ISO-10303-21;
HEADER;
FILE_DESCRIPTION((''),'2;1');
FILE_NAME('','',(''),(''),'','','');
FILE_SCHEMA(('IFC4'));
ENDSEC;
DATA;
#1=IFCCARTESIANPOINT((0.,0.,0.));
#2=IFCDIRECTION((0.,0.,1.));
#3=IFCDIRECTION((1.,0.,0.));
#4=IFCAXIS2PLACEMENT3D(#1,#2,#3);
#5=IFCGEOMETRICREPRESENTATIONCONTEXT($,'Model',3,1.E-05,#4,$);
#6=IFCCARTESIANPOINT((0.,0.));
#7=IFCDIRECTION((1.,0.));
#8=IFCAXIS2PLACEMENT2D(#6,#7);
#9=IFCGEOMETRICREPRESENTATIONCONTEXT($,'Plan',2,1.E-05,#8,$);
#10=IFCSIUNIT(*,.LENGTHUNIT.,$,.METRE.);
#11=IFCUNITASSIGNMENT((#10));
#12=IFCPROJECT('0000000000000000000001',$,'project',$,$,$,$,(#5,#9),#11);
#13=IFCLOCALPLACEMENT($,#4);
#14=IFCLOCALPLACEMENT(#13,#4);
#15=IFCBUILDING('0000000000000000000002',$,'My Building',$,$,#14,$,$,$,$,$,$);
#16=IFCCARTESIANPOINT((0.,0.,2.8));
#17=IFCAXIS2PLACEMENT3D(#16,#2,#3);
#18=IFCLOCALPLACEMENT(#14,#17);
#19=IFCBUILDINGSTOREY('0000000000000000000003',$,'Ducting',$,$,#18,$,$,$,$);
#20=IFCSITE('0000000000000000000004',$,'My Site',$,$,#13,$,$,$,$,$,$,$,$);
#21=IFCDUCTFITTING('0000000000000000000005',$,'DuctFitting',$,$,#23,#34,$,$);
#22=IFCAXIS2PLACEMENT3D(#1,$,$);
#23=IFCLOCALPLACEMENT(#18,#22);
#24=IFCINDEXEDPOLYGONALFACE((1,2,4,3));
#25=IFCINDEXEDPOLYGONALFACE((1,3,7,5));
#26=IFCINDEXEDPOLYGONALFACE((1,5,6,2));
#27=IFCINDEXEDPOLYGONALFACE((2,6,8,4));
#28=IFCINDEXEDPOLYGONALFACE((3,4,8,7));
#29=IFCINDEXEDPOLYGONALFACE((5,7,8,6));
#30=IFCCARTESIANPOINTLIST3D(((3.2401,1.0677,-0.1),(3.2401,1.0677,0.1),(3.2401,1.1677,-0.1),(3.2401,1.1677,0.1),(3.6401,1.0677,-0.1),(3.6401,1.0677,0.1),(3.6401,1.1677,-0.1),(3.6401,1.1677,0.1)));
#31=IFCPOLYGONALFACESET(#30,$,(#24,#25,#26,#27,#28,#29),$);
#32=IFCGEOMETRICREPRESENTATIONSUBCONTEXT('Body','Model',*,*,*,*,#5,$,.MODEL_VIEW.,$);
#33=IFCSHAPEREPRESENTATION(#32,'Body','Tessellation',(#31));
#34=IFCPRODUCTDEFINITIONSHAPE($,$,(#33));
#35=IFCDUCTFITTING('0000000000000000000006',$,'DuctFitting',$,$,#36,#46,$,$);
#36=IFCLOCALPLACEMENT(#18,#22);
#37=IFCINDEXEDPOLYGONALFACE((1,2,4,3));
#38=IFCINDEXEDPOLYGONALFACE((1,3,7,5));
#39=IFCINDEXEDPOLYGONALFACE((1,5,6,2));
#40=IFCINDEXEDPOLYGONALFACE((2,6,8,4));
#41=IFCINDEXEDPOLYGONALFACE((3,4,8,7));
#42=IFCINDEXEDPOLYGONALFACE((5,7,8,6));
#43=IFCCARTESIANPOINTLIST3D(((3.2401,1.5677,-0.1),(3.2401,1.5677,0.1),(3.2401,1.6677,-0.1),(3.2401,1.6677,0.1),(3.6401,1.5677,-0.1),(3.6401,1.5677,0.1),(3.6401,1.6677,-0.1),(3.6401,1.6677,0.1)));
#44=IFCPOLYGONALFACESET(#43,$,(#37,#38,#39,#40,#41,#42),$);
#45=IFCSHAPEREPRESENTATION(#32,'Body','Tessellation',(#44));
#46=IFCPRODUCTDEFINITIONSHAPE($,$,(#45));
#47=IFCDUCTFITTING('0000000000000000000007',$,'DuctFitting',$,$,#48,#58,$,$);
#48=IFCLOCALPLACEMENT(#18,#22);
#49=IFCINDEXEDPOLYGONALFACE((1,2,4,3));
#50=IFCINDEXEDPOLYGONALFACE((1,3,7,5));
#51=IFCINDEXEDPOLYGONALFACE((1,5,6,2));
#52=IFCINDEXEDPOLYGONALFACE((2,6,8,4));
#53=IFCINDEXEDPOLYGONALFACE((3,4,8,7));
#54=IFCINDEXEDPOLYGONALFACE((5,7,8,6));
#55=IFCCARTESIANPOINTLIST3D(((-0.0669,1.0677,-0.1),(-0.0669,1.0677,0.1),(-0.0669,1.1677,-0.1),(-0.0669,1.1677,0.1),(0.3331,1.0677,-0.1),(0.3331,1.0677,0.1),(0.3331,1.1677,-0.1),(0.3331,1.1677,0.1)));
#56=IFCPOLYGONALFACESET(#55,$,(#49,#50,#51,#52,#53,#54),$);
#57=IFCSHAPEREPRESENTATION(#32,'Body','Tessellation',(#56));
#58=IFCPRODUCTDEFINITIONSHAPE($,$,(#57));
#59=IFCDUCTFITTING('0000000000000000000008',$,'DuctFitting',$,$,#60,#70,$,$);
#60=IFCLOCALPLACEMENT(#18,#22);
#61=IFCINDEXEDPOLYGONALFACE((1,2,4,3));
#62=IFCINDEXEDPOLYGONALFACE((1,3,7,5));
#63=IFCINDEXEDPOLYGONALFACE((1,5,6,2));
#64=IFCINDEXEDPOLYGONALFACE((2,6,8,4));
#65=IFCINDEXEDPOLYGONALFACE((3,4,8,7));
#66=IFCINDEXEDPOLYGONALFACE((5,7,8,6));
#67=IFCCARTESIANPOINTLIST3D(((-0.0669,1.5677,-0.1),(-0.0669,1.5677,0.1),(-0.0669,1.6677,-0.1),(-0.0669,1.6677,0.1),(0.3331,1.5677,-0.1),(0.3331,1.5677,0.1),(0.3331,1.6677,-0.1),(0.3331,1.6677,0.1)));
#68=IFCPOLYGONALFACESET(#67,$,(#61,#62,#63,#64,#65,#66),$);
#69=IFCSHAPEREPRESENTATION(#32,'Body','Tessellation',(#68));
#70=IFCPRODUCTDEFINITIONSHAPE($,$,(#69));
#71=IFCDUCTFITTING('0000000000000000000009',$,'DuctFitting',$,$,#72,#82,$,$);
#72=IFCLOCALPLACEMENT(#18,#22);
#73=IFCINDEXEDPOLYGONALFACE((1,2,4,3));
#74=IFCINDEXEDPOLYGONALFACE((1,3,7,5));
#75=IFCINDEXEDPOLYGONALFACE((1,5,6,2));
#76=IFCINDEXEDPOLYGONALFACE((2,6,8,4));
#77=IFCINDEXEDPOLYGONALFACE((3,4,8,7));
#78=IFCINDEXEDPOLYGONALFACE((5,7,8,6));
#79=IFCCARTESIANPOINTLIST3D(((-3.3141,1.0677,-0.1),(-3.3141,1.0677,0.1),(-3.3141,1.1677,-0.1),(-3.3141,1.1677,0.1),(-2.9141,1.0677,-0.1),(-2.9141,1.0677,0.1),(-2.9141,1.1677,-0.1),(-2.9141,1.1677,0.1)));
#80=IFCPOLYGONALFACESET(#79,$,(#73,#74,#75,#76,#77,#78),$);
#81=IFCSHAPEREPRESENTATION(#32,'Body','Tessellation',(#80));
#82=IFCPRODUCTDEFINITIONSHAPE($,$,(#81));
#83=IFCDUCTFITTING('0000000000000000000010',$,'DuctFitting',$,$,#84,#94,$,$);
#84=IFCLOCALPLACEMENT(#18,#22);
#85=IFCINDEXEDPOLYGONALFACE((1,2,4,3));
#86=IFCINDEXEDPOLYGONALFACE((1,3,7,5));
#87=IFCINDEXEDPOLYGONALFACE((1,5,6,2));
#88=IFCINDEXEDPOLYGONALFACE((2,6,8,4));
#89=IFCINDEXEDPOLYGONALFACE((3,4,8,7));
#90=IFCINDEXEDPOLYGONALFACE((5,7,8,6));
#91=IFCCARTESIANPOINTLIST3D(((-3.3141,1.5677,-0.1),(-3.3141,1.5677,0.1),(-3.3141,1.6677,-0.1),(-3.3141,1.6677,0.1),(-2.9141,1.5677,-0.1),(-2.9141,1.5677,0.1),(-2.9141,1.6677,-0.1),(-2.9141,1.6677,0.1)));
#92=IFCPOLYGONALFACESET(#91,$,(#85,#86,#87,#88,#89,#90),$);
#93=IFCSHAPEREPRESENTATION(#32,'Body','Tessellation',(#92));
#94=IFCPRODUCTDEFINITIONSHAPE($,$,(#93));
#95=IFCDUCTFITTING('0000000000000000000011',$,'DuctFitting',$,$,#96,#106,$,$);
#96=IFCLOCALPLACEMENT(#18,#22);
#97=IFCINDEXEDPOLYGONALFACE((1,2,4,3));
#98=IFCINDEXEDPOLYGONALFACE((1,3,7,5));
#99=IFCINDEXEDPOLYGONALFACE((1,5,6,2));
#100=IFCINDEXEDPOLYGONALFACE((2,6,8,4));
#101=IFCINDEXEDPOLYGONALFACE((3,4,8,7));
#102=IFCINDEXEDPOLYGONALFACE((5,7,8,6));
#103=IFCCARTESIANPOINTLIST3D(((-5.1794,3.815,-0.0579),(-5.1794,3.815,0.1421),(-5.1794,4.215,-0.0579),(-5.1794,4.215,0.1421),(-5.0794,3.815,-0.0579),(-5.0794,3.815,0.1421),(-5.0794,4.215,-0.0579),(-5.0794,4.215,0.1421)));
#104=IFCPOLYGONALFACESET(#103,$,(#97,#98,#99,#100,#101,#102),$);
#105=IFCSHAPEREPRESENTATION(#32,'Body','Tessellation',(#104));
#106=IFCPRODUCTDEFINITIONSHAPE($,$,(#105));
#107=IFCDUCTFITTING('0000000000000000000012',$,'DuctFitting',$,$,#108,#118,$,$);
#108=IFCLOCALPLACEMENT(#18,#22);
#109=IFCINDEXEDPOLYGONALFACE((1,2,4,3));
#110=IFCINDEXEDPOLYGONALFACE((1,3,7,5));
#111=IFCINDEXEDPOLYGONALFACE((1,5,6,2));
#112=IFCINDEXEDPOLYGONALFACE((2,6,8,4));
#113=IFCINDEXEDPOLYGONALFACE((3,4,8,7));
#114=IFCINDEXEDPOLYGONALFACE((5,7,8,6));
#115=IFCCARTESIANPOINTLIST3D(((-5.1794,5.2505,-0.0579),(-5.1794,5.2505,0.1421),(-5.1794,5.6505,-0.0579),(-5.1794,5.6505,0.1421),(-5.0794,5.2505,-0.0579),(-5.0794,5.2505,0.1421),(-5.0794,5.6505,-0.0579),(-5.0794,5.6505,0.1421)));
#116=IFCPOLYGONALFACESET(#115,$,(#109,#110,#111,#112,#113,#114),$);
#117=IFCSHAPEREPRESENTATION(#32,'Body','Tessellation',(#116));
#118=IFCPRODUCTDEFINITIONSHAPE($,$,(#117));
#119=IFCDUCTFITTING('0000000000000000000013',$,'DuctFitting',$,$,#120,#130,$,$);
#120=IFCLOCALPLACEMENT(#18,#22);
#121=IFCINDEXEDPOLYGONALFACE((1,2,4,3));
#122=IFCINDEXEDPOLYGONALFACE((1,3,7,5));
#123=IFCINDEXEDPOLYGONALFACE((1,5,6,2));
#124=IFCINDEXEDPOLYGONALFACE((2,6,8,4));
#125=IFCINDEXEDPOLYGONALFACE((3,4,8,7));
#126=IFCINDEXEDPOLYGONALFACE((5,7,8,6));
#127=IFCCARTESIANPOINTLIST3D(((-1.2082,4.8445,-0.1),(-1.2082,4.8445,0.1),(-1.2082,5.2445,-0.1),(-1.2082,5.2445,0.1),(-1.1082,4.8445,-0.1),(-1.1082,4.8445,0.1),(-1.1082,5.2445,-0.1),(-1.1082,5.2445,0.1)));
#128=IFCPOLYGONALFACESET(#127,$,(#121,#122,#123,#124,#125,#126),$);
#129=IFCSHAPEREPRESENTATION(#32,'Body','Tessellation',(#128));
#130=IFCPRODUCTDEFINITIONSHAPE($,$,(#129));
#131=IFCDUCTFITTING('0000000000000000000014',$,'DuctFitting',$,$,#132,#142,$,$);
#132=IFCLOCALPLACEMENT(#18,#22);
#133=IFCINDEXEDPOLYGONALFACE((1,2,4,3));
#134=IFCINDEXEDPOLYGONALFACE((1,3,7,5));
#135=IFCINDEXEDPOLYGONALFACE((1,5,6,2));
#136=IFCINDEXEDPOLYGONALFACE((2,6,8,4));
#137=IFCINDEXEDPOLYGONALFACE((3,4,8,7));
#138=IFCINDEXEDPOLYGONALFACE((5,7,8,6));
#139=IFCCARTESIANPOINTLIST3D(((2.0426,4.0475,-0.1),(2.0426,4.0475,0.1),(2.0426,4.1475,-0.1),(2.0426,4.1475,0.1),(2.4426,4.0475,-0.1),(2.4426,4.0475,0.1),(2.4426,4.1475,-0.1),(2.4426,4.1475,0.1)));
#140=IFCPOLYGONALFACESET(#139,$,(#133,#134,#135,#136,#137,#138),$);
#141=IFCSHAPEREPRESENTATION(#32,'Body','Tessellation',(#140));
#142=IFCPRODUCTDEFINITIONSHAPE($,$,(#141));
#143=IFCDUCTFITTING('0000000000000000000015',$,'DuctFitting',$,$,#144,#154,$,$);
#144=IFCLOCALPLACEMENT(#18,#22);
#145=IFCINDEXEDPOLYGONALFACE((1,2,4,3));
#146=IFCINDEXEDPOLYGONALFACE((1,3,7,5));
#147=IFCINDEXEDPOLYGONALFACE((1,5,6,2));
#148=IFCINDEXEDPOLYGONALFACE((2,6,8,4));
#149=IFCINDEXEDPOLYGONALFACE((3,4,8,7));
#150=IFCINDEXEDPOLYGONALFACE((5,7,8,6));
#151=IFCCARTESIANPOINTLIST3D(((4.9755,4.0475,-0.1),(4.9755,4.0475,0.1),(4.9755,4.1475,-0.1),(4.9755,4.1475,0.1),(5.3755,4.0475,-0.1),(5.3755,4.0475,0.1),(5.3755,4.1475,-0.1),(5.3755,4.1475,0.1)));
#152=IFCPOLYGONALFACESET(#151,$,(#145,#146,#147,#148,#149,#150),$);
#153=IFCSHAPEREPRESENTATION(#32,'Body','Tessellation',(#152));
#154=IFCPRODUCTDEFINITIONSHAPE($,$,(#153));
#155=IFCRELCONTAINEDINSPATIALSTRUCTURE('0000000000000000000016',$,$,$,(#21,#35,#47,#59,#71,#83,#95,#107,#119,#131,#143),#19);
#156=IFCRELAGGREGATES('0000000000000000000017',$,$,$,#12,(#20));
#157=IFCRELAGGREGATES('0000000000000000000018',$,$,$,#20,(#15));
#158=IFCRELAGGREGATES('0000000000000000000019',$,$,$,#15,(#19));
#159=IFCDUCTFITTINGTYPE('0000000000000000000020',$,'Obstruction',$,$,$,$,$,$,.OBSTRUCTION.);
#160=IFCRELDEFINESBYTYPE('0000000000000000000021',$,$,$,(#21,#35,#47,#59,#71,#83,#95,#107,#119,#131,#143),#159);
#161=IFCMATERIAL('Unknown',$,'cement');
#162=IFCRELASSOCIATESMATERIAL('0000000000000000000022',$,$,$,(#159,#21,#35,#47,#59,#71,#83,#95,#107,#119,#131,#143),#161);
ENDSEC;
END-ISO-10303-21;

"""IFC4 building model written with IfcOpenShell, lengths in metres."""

from ifc_helpers import new_model, si_unit, frame, origin_with_axes, origin_2d_with_axis, place, context, subcontext, project, spatial, rectangle, extrude, material, material_profile, profile_set, profile_usage, type_object, element, save


model = new_model("IFC4")

# Units and contexts
model_context = context("Model", 3, precision=1e-05, world=origin_with_axes())
plan_context = context("Plan", 2, precision=1e-05, world=origin_2d_with_axis())
body_context = subcontext(model_context, "Body", "Model", "MODEL_VIEW")
ifc_project = project(units=[si_unit("LENGTHUNIT", "METRE")], contexts=[model_context, plan_context])

# Site, building, storey
site_placement = place(None, origin_with_axes())
site = spatial("IfcSite", under=ifc_project, at=site_placement, Name="My Site")
building_placement = place(site_placement, origin_with_axes())
building = spatial("IfcBuilding", under=site, at=building_placement, Name="My Building")
storey_placement = place(building_placement, frame((0.0, 0.0, 2.8), z_axis=(0.0, 0.0, 1.0), x_axis=(1.0, 0.0, 0.0)))
storey = spatial("IfcBuildingStorey", under=building, at=storey_placement, Name="Ducting")

# Shared definitions
ifc_material = material(Name="Unknown", Category="cement")

# Duct fittings
ifc_material_profile_1 = material_profile(ifc_material, rectangle(XDim=0.4, YDim=0.2))
ifc_profile_set_1 = profile_set([ifc_material_profile_1])
ifc_profile_usage_1 = profile_usage(ifc_profile_set_1, cardinal=5)
duct_fitting_type_1 = type_object("IfcDuctFittingType", Name="Obstruction", PredefinedType="OBSTRUCTION", material=ifc_profile_set_1)
duct_fitting_1_placement = place(storey_placement, frame((3.4401, 1.0677, 0.0), z_axis=(0.0, 1.0, 0.0), x_axis=(-1.0, 0.0, 0.0)))
element("IfcDuctFitting", 1, at=duct_fitting_1_placement, inside=storey, type_object=duct_fitting_type_1, material=ifc_profile_usage_1, Name="DuctFitting", context=body_context, shape_type="SweptSolid", body=[
    extrude(rectangle(XDim=0.4, YDim=0.2), origin_with_axes(), (0.0, 0.0, 1.0), 0.1),
])
ifc_profile_usage_2 = profile_usage(ifc_profile_set_1, cardinal=5)
duct_fitting_2_placement = place(storey_placement, frame((3.4401, 1.6677, 0.0), z_axis=(0.0, -1.0, 0.0), x_axis=(1.0, 0.0, 0.0)))
element("IfcDuctFitting", 2, at=duct_fitting_2_placement, inside=storey, type_object=duct_fitting_type_1, material=ifc_profile_usage_2, Name="DuctFitting", context=body_context, shape_type="SweptSolid", body=[
    extrude(rectangle(XDim=0.4, YDim=0.2), origin_with_axes(), (0.0, 0.0, 1.0), 0.1),
])
ifc_profile_usage_3 = profile_usage(ifc_profile_set_1, cardinal=5)
duct_fitting_3_placement = place(storey_placement, frame((0.1331, 1.0677, 0.0), z_axis=(0.0, 1.0, 0.0), x_axis=(-1.0, 0.0, 0.0)))
element("IfcDuctFitting", 3, at=duct_fitting_3_placement, inside=storey, type_object=duct_fitting_type_1, material=ifc_profile_usage_3, Name="DuctFitting", context=body_context, shape_type="SweptSolid", body=[
    extrude(rectangle(XDim=0.4, YDim=0.2), origin_with_axes(), (0.0, 0.0, 1.0), 0.1),
])
ifc_profile_usage_4 = profile_usage(ifc_profile_set_1, cardinal=5)
duct_fitting_4_placement = place(storey_placement, frame((0.1331, 1.6677, 0.0), z_axis=(0.0, -1.0, 0.0), x_axis=(1.0, 0.0, 0.0)))
element("IfcDuctFitting", 4, at=duct_fitting_4_placement, inside=storey, type_object=duct_fitting_type_1, material=ifc_profile_usage_4, Name="DuctFitting", context=body_context, shape_type="SweptSolid", body=[
    extrude(rectangle(XDim=0.4, YDim=0.2), origin_with_axes(), (0.0, 0.0, 1.0), 0.1),
])
ifc_profile_usage_5 = profile_usage(ifc_profile_set_1, cardinal=5)
duct_fitting_5_placement = place(storey_placement, frame((-3.1141, 1.0677, 0.0), z_axis=(0.0, 1.0, 0.0), x_axis=(-1.0, 0.0, 0.0)))
element("IfcDuctFitting", 5, at=duct_fitting_5_placement, inside=storey, type_object=duct_fitting_type_1, material=ifc_profile_usage_5, Name="DuctFitting", context=body_context, shape_type="SweptSolid", body=[
    extrude(rectangle(XDim=0.4, YDim=0.2), origin_with_axes(), (0.0, 0.0, 1.0), 0.1),
])
ifc_profile_usage_6 = profile_usage(ifc_profile_set_1, cardinal=5)
duct_fitting_6_placement = place(storey_placement, frame((-3.1141, 1.6677, 0.0), z_axis=(0.0, -1.0, 0.0), x_axis=(1.0, 0.0, 0.0)))
element("IfcDuctFitting", 6, at=duct_fitting_6_placement, inside=storey, type_object=duct_fitting_type_1, material=ifc_profile_usage_6, Name="DuctFitting", context=body_context, shape_type="SweptSolid", body=[
    extrude(rectangle(XDim=0.4, YDim=0.2), origin_with_axes(), (0.0, 0.0, 1.0), 0.1),
])
ifc_profile_usage_7 = profile_usage(ifc_profile_set_1, cardinal=5)
duct_fitting_7_placement = place(storey_placement, frame((-5.0794, 4.015, 0.0421), z_axis=(-1.0, 0.0, 0.0), x_axis=(0.0, -1.0, 0.0)))
element("IfcDuctFitting", 7, at=duct_fitting_7_placement, inside=storey, type_object=duct_fitting_type_1, material=ifc_profile_usage_7, Name="DuctFitting", context=body_context, shape_type="SweptSolid", body=[
    extrude(rectangle(XDim=0.4, YDim=0.2), origin_with_axes(), (0.0, 0.0, 1.0), 0.1),
])
ifc_profile_usage_8 = profile_usage(ifc_profile_set_1, cardinal=5)
duct_fitting_8_placement = place(storey_placement, frame((-5.0794, 5.4505, 0.0421), z_axis=(-1.0, 0.0, 0.0), x_axis=(0.0, -1.0, 0.0)))
element("IfcDuctFitting", 8, at=duct_fitting_8_placement, inside=storey, type_object=duct_fitting_type_1, material=ifc_profile_usage_8, Name="DuctFitting", context=body_context, shape_type="SweptSolid", body=[
    extrude(rectangle(XDim=0.4, YDim=0.2), origin_with_axes(), (0.0, 0.0, 1.0), 0.1),
])
ifc_profile_usage_9 = profile_usage(ifc_profile_set_1, cardinal=5)
duct_fitting_9_placement = place(storey_placement, frame((-1.2082, 5.0445, 0.0), z_axis=(1.0, 0.0, 0.0), x_axis=(0.0, 1.0, 0.0)))
element("IfcDuctFitting", 9, at=duct_fitting_9_placement, inside=storey, type_object=duct_fitting_type_1, material=ifc_profile_usage_9, Name="DuctFitting", context=body_context, shape_type="SweptSolid", body=[
    extrude(rectangle(XDim=0.4, YDim=0.2), origin_with_axes(), (0.0, 0.0, 1.0), 0.1),
])
ifc_profile_usage_10 = profile_usage(ifc_profile_set_1, cardinal=5)
duct_fitting_10_placement = place(storey_placement, frame((2.2426, 4.1475, 0.0), z_axis=(0.0, -1.0, 0.0), x_axis=(1.0, 0.0, 0.0)))
element("IfcDuctFitting", 10, at=duct_fitting_10_placement, inside=storey, type_object=duct_fitting_type_1, material=ifc_profile_usage_10, Name="DuctFitting", context=body_context, shape_type="SweptSolid", body=[
    extrude(rectangle(XDim=0.4, YDim=0.2), origin_with_axes(), (0.0, 0.0, 1.0), 0.1),
])
ifc_profile_usage_11 = profile_usage(ifc_profile_set_1, cardinal=5)
duct_fitting_11_placement = place(storey_placement, frame((5.1755, 4.1475, 0.0), z_axis=(0.0, -1.0, 0.0), x_axis=(1.0, 0.0, 0.0)))
element("IfcDuctFitting", 11, at=duct_fitting_11_placement, inside=storey, type_object=duct_fitting_type_1, material=ifc_profile_usage_11, Name="DuctFitting", context=body_context, shape_type="SweptSolid", body=[
    extrude(rectangle(XDim=0.4, YDim=0.2), origin_with_axes(), (0.0, 0.0, 1.0), 0.1),
])

save(model, "model.ifc")
